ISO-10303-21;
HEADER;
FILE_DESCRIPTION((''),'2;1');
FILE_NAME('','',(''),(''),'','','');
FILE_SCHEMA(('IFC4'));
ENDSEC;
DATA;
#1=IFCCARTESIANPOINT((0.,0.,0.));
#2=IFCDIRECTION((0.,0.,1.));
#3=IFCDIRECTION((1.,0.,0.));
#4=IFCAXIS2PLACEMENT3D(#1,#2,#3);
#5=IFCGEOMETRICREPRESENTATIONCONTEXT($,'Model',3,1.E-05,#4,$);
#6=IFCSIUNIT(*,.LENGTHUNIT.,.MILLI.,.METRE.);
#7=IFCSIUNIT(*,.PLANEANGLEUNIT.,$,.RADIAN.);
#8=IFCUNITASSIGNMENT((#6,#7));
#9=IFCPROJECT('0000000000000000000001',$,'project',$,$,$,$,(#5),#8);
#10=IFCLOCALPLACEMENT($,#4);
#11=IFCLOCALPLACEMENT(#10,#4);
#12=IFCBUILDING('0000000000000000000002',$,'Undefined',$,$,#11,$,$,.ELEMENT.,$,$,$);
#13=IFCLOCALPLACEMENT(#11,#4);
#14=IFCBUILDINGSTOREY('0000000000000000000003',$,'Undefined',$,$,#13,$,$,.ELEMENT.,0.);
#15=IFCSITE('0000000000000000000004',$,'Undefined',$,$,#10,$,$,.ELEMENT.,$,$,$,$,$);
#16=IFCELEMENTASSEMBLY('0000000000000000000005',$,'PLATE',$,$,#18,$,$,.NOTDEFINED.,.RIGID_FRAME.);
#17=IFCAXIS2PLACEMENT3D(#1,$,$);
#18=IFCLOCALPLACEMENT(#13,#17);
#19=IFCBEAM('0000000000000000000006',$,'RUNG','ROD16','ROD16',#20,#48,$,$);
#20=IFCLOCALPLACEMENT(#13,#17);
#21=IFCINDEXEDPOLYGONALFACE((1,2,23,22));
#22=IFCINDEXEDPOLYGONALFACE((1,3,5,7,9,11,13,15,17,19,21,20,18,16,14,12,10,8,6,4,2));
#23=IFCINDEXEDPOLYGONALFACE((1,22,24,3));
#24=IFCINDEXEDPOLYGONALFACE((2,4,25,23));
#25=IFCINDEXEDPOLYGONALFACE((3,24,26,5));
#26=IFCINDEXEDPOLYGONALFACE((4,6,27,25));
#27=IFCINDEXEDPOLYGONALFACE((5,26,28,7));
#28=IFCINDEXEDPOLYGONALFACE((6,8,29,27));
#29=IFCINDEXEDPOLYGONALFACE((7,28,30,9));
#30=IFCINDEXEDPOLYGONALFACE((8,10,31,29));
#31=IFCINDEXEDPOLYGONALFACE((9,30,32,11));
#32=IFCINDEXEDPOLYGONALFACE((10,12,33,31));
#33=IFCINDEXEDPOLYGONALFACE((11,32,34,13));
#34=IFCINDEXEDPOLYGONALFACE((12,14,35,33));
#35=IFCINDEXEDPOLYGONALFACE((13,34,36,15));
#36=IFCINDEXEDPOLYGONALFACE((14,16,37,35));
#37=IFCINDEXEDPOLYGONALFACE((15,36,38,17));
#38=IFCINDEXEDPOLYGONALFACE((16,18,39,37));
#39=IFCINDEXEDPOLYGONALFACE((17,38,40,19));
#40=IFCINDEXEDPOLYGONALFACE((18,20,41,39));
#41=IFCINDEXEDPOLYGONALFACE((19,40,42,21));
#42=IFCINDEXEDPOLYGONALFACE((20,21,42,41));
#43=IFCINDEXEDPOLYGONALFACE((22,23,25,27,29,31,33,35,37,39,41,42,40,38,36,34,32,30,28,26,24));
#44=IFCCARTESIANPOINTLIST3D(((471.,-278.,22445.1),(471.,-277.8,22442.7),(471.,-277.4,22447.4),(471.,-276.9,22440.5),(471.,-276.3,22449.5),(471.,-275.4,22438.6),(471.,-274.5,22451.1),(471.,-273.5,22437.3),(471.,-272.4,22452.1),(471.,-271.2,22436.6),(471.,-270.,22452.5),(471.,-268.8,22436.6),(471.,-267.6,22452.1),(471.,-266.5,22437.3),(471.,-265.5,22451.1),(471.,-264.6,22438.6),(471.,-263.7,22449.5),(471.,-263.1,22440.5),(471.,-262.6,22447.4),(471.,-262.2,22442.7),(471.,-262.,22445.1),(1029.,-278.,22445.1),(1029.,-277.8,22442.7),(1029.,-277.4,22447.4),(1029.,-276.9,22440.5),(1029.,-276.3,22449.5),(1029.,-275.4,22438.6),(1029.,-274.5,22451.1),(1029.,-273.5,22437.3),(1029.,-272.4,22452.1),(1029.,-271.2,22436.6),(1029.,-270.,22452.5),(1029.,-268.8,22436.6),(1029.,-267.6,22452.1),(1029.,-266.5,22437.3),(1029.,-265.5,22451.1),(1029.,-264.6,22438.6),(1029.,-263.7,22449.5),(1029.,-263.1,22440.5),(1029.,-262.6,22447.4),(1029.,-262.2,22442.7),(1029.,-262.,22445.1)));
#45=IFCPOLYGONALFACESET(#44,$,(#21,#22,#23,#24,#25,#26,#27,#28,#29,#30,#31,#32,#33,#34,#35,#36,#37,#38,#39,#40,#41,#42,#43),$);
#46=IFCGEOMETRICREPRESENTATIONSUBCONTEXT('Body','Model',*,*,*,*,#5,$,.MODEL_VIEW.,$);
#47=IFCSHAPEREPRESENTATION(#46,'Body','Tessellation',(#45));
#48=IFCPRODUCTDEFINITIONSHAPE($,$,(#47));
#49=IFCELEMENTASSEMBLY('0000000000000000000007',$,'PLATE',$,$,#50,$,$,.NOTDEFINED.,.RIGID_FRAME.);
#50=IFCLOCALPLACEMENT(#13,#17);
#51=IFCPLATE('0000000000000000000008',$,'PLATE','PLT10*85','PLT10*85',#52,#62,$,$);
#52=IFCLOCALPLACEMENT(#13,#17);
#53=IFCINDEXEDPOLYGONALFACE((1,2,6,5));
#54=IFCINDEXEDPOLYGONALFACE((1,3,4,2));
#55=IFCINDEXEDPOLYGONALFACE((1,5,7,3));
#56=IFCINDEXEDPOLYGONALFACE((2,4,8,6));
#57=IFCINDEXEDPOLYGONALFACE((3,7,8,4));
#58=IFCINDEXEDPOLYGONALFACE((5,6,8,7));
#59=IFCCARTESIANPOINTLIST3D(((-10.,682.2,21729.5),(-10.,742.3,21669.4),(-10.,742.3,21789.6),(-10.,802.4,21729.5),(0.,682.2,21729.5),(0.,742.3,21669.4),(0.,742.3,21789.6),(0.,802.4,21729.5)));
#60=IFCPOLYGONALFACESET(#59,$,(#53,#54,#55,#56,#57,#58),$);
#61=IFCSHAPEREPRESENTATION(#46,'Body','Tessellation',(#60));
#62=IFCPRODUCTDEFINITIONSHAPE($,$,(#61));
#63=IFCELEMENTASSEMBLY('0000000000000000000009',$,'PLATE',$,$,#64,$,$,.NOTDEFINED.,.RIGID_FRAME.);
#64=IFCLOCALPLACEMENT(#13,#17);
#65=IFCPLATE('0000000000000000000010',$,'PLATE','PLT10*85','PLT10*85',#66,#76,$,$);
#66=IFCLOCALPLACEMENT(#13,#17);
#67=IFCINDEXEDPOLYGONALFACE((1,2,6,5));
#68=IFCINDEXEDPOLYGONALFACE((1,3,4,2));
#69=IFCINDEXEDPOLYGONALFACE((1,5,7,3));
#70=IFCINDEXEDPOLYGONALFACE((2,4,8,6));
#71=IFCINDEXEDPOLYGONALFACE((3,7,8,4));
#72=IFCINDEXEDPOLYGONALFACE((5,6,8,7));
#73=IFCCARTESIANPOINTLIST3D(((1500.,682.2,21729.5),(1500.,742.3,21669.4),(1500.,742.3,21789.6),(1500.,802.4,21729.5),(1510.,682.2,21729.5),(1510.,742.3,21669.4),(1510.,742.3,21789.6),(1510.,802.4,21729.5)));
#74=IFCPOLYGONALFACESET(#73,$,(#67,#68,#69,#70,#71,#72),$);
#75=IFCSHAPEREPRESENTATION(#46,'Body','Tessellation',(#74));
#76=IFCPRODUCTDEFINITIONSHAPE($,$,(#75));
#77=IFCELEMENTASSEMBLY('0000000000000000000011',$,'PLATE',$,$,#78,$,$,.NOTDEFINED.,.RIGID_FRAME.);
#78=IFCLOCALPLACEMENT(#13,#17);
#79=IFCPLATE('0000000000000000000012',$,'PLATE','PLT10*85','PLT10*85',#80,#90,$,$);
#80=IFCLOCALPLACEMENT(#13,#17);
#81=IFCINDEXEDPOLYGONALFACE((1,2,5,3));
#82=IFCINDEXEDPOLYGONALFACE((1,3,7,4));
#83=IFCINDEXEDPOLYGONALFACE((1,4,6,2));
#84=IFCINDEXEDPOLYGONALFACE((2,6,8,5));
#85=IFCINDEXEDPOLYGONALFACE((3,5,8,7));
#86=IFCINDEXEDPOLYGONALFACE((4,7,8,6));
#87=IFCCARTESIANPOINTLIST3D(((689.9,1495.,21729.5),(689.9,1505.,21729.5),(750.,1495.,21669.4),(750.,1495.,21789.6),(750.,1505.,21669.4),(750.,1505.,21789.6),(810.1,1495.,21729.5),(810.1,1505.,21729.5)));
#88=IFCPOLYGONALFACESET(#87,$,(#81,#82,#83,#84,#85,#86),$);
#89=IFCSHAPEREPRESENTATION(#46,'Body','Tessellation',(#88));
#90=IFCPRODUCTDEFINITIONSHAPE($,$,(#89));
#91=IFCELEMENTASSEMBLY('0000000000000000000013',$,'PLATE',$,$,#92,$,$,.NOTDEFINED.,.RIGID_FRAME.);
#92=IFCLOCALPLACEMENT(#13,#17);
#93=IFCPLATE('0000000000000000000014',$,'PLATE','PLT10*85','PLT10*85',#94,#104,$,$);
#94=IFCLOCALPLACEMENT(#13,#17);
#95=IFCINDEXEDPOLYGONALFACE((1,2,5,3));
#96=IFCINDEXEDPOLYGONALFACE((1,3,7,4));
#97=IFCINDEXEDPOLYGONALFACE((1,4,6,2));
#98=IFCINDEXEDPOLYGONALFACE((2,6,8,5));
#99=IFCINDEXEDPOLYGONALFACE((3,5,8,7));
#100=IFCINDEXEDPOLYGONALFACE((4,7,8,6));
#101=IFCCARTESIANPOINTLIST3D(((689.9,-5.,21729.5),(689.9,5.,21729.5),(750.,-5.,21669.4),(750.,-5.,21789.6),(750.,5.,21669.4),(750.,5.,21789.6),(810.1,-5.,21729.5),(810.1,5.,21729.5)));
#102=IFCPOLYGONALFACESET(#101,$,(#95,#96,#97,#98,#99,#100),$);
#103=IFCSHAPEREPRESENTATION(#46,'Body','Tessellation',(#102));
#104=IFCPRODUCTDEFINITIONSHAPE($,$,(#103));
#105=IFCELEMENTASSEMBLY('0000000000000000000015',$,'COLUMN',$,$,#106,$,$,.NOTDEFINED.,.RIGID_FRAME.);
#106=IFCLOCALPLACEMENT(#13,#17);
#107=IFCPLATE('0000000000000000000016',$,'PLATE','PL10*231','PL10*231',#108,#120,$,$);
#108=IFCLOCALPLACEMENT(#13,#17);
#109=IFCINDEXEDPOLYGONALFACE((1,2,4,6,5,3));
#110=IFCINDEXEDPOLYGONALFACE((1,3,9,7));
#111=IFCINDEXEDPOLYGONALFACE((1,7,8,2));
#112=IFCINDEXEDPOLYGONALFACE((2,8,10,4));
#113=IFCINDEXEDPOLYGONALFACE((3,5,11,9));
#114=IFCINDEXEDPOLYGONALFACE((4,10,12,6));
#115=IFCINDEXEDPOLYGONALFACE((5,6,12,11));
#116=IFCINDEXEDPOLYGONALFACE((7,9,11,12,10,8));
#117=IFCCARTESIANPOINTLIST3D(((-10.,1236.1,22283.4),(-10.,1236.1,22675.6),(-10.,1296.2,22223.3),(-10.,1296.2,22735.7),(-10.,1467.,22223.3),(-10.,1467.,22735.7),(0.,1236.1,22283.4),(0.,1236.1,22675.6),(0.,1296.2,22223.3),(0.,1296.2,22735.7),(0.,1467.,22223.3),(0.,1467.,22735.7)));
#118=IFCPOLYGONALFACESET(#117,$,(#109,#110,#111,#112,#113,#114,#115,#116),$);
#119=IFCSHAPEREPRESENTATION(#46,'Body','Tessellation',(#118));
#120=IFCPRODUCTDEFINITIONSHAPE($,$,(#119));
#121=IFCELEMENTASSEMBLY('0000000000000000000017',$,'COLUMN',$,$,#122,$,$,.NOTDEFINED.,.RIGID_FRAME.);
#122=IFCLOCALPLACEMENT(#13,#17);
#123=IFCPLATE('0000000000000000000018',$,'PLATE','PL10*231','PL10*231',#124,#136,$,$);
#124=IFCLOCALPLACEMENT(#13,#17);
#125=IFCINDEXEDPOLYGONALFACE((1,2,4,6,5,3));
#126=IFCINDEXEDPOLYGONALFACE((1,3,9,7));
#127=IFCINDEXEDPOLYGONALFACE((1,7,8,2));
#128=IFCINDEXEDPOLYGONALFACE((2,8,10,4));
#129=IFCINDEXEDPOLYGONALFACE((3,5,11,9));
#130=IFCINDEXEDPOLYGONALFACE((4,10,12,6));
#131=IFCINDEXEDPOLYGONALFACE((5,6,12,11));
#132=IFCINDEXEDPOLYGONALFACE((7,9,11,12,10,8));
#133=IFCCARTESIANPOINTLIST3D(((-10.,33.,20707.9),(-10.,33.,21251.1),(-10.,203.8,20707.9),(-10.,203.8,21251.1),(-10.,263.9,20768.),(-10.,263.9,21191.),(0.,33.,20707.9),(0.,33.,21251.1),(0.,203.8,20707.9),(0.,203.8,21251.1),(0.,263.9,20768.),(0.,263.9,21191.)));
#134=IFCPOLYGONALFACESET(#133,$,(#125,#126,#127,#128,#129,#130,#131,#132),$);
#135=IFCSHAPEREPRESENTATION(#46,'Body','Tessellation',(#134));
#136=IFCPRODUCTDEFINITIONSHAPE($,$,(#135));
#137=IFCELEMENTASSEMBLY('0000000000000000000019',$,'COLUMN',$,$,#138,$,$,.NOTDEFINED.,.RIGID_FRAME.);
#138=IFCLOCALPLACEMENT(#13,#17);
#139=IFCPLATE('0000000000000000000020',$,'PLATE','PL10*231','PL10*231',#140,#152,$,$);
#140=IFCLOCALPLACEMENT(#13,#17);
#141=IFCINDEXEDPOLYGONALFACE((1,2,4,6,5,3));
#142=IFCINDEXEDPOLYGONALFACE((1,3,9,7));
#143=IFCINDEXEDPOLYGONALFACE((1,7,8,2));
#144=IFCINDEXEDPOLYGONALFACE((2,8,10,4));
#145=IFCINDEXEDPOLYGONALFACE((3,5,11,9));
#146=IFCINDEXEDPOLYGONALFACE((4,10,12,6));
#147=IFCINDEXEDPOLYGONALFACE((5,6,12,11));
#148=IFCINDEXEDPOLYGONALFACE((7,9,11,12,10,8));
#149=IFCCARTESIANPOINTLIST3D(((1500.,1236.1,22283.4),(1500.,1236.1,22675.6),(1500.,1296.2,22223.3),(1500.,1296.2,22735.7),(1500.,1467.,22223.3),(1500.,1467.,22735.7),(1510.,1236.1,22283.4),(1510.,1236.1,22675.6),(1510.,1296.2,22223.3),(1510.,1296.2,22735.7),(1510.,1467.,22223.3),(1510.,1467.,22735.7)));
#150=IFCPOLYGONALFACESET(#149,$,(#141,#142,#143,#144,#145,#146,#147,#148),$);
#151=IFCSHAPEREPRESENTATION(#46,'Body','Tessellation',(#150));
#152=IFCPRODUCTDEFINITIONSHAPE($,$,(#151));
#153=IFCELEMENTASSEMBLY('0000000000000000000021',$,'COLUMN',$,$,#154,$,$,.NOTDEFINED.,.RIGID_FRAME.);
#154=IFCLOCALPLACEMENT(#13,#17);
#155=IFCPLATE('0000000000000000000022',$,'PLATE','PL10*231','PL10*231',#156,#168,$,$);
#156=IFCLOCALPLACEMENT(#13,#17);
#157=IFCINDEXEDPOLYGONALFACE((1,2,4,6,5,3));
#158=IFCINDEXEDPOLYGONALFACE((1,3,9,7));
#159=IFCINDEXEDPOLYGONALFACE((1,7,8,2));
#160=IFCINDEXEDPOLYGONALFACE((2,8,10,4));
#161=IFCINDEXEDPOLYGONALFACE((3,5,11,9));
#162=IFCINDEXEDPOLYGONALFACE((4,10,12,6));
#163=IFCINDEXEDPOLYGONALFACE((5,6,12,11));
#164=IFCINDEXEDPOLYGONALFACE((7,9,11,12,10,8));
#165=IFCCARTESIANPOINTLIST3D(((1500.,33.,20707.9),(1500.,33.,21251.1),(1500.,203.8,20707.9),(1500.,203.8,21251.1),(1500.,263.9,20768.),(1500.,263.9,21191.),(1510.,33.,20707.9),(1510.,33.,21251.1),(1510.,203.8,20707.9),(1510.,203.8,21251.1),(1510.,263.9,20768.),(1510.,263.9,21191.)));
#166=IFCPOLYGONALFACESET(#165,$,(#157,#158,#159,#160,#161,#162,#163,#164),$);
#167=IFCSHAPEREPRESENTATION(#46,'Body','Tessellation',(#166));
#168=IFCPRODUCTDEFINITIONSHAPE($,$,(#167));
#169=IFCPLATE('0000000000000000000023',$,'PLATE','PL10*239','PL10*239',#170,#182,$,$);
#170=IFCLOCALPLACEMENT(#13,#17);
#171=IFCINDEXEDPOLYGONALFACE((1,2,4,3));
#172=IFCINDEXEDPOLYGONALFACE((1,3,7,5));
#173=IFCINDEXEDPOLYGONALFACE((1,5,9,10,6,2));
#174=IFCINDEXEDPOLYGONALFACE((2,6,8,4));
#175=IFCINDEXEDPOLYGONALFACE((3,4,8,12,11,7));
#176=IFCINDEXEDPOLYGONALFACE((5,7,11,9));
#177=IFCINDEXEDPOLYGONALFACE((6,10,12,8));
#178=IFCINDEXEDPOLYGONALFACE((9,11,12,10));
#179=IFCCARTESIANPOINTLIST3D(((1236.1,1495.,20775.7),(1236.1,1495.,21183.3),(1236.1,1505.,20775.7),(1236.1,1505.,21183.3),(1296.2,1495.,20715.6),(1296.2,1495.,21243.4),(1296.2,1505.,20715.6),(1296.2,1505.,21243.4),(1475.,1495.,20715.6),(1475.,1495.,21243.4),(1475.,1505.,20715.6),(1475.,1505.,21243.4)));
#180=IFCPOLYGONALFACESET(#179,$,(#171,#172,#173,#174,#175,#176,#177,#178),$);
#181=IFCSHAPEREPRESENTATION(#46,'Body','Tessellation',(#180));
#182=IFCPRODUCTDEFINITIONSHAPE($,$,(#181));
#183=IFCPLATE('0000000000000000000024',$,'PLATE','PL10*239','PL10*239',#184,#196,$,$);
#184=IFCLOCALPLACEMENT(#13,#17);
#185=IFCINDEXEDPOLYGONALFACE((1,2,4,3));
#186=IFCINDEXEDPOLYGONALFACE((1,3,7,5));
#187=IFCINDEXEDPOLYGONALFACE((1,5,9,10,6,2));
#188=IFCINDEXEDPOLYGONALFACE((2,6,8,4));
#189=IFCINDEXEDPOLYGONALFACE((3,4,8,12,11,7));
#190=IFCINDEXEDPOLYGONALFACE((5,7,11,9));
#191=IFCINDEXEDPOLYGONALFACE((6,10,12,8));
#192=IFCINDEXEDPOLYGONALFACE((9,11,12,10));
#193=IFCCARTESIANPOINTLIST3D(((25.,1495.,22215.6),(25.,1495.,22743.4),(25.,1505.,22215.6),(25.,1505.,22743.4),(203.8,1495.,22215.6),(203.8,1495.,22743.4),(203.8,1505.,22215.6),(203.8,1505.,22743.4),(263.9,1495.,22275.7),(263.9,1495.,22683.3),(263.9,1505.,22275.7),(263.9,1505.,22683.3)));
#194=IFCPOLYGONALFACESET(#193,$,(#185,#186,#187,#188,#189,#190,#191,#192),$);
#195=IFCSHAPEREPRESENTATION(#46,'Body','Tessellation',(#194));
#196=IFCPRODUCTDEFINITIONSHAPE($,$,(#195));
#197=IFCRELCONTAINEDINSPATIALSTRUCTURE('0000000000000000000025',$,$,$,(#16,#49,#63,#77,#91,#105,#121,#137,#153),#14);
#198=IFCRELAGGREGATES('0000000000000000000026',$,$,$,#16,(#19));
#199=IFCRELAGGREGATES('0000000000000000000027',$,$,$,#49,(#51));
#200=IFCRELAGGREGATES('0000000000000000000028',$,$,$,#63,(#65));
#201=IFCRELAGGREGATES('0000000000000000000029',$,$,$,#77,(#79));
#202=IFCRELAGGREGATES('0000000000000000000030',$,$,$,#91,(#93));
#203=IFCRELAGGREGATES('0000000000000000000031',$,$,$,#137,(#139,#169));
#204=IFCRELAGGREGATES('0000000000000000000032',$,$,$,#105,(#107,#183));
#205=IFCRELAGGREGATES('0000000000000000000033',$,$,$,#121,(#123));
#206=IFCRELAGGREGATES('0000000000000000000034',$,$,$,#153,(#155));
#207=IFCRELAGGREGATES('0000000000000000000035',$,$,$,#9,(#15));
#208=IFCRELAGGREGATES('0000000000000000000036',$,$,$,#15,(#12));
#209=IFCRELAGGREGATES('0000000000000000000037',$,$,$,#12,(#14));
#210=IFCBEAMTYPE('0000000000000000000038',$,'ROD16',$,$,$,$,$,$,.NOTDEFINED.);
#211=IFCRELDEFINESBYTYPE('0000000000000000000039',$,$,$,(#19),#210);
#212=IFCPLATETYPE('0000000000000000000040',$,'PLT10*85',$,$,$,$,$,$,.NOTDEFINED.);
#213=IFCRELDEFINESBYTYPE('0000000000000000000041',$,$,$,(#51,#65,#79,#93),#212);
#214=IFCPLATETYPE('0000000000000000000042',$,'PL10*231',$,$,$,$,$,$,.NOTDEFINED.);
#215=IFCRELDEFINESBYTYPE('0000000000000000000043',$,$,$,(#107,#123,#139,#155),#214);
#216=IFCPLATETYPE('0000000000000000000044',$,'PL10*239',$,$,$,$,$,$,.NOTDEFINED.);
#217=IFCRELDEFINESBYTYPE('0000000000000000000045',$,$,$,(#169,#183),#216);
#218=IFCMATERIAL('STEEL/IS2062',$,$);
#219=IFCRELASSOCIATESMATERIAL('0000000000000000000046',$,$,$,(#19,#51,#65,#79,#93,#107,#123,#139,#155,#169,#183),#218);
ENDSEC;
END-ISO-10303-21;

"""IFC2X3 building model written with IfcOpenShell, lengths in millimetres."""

from ifc_helpers import new_model, si_unit, frame, origin_with_axes, origin_2d_with_axis, place, context, subcontext, project, spatial, polyline, circle, outline, extrude, material, type_object, element, aggregate, save


model = new_model("IFC2X3")

# Units and contexts
model_context = context("Model", 3, precision=1e-05, world=origin_with_axes())
body_context = subcontext(model_context, "Body", "Model", "MODEL_VIEW")
ifc_project = project(units=[si_unit("LENGTHUNIT", "METRE", prefix="MILLI"), si_unit("PLANEANGLEUNIT", "RADIAN")], contexts=[model_context])

# Site, building, storey
site_placement = place(None, origin_with_axes())
site = spatial("IfcSite", under=ifc_project, at=site_placement, Name="Undefined", CompositionType="ELEMENT")
building_placement = place(site_placement, origin_with_axes())
building = spatial("IfcBuilding", under=site, at=building_placement, Name="Undefined", CompositionType="ELEMENT")
storey_placement = place(building_placement, origin_with_axes())
storey = spatial("IfcBuildingStorey", under=building, at=storey_placement, Name="Undefined", CompositionType="ELEMENT", Elevation=0.0)

# Shared definitions
ifc_material = material(Name="STEEL/IS2062")

# Element assembly, beam
assembly_1_placement = place(storey_placement, origin_with_axes())
assembly_1 = element("IfcElementAssembly", 1, at=assembly_1_placement, inside=storey, Name="PLATE", AssemblyPlace="NOTDEFINED", PredefinedType="RIGID_FRAME")
beam_type_1 = type_object("IfcBeamType", Name="ROD16", PredefinedType="NOTDEFINED")
beam_1_placement = place(assembly_1_placement, frame((471.0, -270.0, 22444.5), z_axis=(0.0, 1.0, 0.0), x_axis=(1.0, 0.0, 0.0)))
beam_1 = element("IfcBeam", 2, at=beam_1_placement, type_object=beam_type_1, material=ifc_material, Name="RUNG", Description="ROD16", ObjectType="ROD16", context=body_context, shape_type="SweptSolid", body=[
    extrude(circle(Radius=8.0, at=origin_2d_with_axis()), frame((558.0, 0.0, 0.0), z_axis=(-1.0, 0.0, 0.0), x_axis=(0.0, -1.0, 0.0)), (0.0, 0.0, 1.0), 558.0),
])
aggregate(assembly_1, [beam_1])

# Element assemblies, plates
assembly_2_placement = place(storey_placement, origin_with_axes())
assembly_2 = element("IfcElementAssembly", 3, at=assembly_2_placement, inside=storey, Name="PLATE", AssemblyPlace="NOTDEFINED", PredefinedType="RIGID_FRAME")
plate_type_1 = type_object("IfcPlateType", Name="PLT10*85", PredefinedType="NOTDEFINED")
plate_1_placement = place(assembly_2_placement, frame((-5.0, 742.3, 21789.6), z_axis=(1.0, 0.0, 0.0), x_axis=(0.0, -0.707107, -0.707107)))
plate_1 = element("IfcPlate", 4, at=plate_1_placement, type_object=plate_type_1, material=ifc_material, Name="PLATE", Description="PLT10*85", ObjectType="PLT10*85", context=body_context, shape_type="SweptSolid", body=[
    extrude(outline(polyline([(0.0, 0.0), (85.0, 0.0), (85.0, 85.0), (0.0, 85.0), (0.0, 0.0)])), frame((0.0, 0.0, -5.0), z_axis=(0.0, 0.0, 1.0), x_axis=(1.0, 0.0, 0.0)), (0.0, 0.0, 1.0), 10.0),
])
aggregate(assembly_2, [plate_1])
assembly_3_placement = place(storey_placement, origin_with_axes())
assembly_3 = element("IfcElementAssembly", 5, at=assembly_3_placement, inside=storey, Name="PLATE", AssemblyPlace="NOTDEFINED", PredefinedType="RIGID_FRAME")
plate_2_placement = place(assembly_3_placement, frame((1505.0, 742.3, 21789.6), z_axis=(1.0, 0.0, 0.0), x_axis=(0.0, -0.707107, -0.707107)))
plate_2 = element("IfcPlate", 6, at=plate_2_placement, type_object=plate_type_1, material=ifc_material, Name="PLATE", Description="PLT10*85", ObjectType="PLT10*85", context=body_context, shape_type="SweptSolid", body=[
    extrude(outline(polyline([(0.0, 0.0), (85.0, 0.0), (85.0, 85.0), (0.0, 85.0), (0.0, 0.0)])), frame((0.0, 0.0, -5.0), z_axis=(0.0, 0.0, 1.0), x_axis=(1.0, 0.0, 0.0)), (0.0, 0.0, 1.0), 10.0),
])
aggregate(assembly_3, [plate_2])
assembly_4_placement = place(storey_placement, origin_with_axes())
assembly_4 = element("IfcElementAssembly", 7, at=assembly_4_placement, inside=storey, Name="PLATE", AssemblyPlace="NOTDEFINED", PredefinedType="RIGID_FRAME")
plate_3_placement = place(assembly_4_placement, frame((750.0, 1500.0, 21789.6), z_axis=(0.0, -1.0, 0.0), x_axis=(-0.707107, 0.0, -0.707107)))
plate_3 = element("IfcPlate", 8, at=plate_3_placement, type_object=plate_type_1, material=ifc_material, Name="PLATE", Description="PLT10*85", ObjectType="PLT10*85", context=body_context, shape_type="SweptSolid", body=[
    extrude(outline(polyline([(0.0, 0.0), (85.0, 0.0), (85.0, 85.0), (0.0, 85.0), (0.0, 0.0)])), frame((0.0, 0.0, -5.0), z_axis=(0.0, 0.0, 1.0), x_axis=(1.0, 0.0, 0.0)), (0.0, 0.0, 1.0), 10.0),
])
aggregate(assembly_4, [plate_3])
assembly_5_placement = place(storey_placement, origin_with_axes())
assembly_5 = element("IfcElementAssembly", 9, at=assembly_5_placement, inside=storey, Name="PLATE", AssemblyPlace="NOTDEFINED", PredefinedType="RIGID_FRAME")
plate_4_placement = place(assembly_5_placement, frame((750.0, 0.0, 21789.6), z_axis=(0.0, -1.0, 0.0), x_axis=(-0.707107, 0.0, -0.707107)))
plate_4 = element("IfcPlate", 10, at=plate_4_placement, type_object=plate_type_1, material=ifc_material, Name="PLATE", Description="PLT10*85", ObjectType="PLT10*85", context=body_context, shape_type="SweptSolid", body=[
    extrude(outline(polyline([(0.0, 0.0), (85.0, 0.0), (85.0, 85.0), (0.0, 85.0), (0.0, 0.0)])), frame((0.0, 0.0, -5.0), z_axis=(0.0, 0.0, 1.0), x_axis=(1.0, 0.0, 0.0)), (0.0, 0.0, 1.0), 10.0),
])
aggregate(assembly_5, [plate_4])
assembly_6_placement = place(storey_placement, origin_with_axes())
assembly_6 = element("IfcElementAssembly", 11, at=assembly_6_placement, inside=storey, Name="COLUMN", AssemblyPlace="NOTDEFINED", PredefinedType="RIGID_FRAME")
plate_type_2 = type_object("IfcPlateType", Name="PL10*231", PredefinedType="NOTDEFINED")
plate_5_placement = place(assembly_6_placement, frame((-5.0, 1467.0, 22223.3), z_axis=(1.0, 0.0, 0.0), x_axis=(0.0, 0.0, 1.0)))
plate_5 = element("IfcPlate", 12, at=plate_5_placement, type_object=plate_type_2, material=ifc_material, Name="PLATE", Description="PL10*231", ObjectType="PL10*231", context=body_context, shape_type="SweptSolid", body=[
    extrude(outline(polyline([(0.0, 0.0), (512.3, 0.0), (512.3, 170.8), (452.2, 230.9), (60.1, 230.9), (0.0, 170.8), (0.0, 0.0)])), frame((0.0, 0.0, -5.0), z_axis=(0.0, 0.0, 1.0), x_axis=(1.0, 0.0, 0.0)), (0.0, 0.0, 1.0), 10.0),
])
assembly_7_placement = place(storey_placement, origin_with_axes())
assembly_7 = element("IfcElementAssembly", 13, at=assembly_7_placement, inside=storey, Name="COLUMN", AssemblyPlace="NOTDEFINED", PredefinedType="RIGID_FRAME")
plate_6_placement = place(assembly_7_placement, frame((-5.0, 33.0, 21251.1), z_axis=(1.0, 0.0, 0.0), x_axis=(0.0, 0.0, -1.0)))
plate_6 = element("IfcPlate", 14, at=plate_6_placement, type_object=plate_type_2, material=ifc_material, Name="PLATE", Description="PL10*231", ObjectType="PL10*231", context=body_context, shape_type="SweptSolid", body=[
    extrude(outline(polyline([(0.0, 0.0), (543.3, 0.0), (543.3, 170.8), (483.2, 230.9), (60.1, 230.9), (0.0, 170.8), (0.0, 0.0)])), frame((0.0, 0.0, -5.0), z_axis=(0.0, 0.0, 1.0), x_axis=(1.0, 0.0, 0.0)), (0.0, 0.0, 1.0), 10.0),
])
assembly_8_placement = place(storey_placement, origin_with_axes())
assembly_8 = element("IfcElementAssembly", 15, at=assembly_8_placement, inside=storey, Name="COLUMN", AssemblyPlace="NOTDEFINED", PredefinedType="RIGID_FRAME")
plate_7_placement = place(assembly_8_placement, frame((1505.0, 1467.0, 22223.3), z_axis=(1.0, 0.0, 0.0), x_axis=(0.0, 0.0, 1.0)))
plate_7 = element("IfcPlate", 16, at=plate_7_placement, type_object=plate_type_2, material=ifc_material, Name="PLATE", Description="PL10*231", ObjectType="PL10*231", context=body_context, shape_type="SweptSolid", body=[
    extrude(outline(polyline([(0.0, 0.0), (512.3, 0.0), (512.3, 170.8), (452.2, 230.9), (60.1, 230.9), (0.0, 170.8), (0.0, 0.0)])), frame((0.0, 0.0, -5.0), z_axis=(0.0, 0.0, 1.0), x_axis=(1.0, 0.0, 0.0)), (0.0, 0.0, 1.0), 10.0),
])
assembly_9_placement = place(storey_placement, origin_with_axes())
assembly_9 = element("IfcElementAssembly", 17, at=assembly_9_placement, inside=storey, Name="COLUMN", AssemblyPlace="NOTDEFINED", PredefinedType="RIGID_FRAME")
plate_8_placement = place(assembly_9_placement, frame((1505.0, 33.0, 21251.1), z_axis=(1.0, 0.0, 0.0), x_axis=(0.0, 0.0, -1.0)))
plate_8 = element("IfcPlate", 18, at=plate_8_placement, type_object=plate_type_2, material=ifc_material, Name="PLATE", Description="PL10*231", ObjectType="PL10*231", context=body_context, shape_type="SweptSolid", body=[
    extrude(outline(polyline([(0.0, 0.0), (543.3, 0.0), (543.3, 170.8), (483.2, 230.9), (60.1, 230.9), (0.0, 170.8), (0.0, 0.0)])), frame((0.0, 0.0, -5.0), z_axis=(0.0, 0.0, 1.0), x_axis=(1.0, 0.0, 0.0)), (0.0, 0.0, 1.0), 10.0),
])

# Plates
plate_type_3 = type_object("IfcPlateType", Name="PL10*239", PredefinedType="NOTDEFINED")
plate_9_placement = place(assembly_8_placement, frame((1475.0, 1500.0, 21243.4), z_axis=(0.0, 1.0, 0.0), x_axis=(0.0, 0.0, -1.0)))
plate_9 = element("IfcPlate", 19, at=plate_9_placement, type_object=plate_type_3, material=ifc_material, Name="PLATE", Description="PL10*239", ObjectType="PL10*239", context=body_context, shape_type="SweptSolid", body=[
    extrude(outline(polyline([(0.0, 0.0), (527.8, 0.0), (527.8, 178.8), (467.7, 238.9), (60.1, 238.9), (0.0, 178.8), (0.0, 0.0)])), frame((0.0, 0.0, -5.0), z_axis=(0.0, 0.0, 1.0), x_axis=(1.0, 0.0, 0.0)), (0.0, 0.0, 1.0), 10.0),
])
aggregate(assembly_8, [plate_7, plate_9])
plate_10_placement = place(assembly_6_placement, frame((25.0, 1500.0, 22215.6), z_axis=(0.0, 1.0, 0.0), x_axis=(0.0, 0.0, 1.0)))
plate_10 = element("IfcPlate", 20, at=plate_10_placement, type_object=plate_type_3, material=ifc_material, Name="PLATE", Description="PL10*239", ObjectType="PL10*239", context=body_context, shape_type="SweptSolid", body=[
    extrude(outline(polyline([(0.0, 0.0), (527.8, 0.0), (527.8, 178.8), (467.7, 238.9), (60.1, 238.9), (0.0, 178.8), (0.0, 0.0)])), frame((0.0, 0.0, -5.0), z_axis=(0.0, 0.0, 1.0), x_axis=(1.0, 0.0, 0.0)), (0.0, 0.0, 1.0), 10.0),
])
aggregate(assembly_6, [plate_5, plate_10])
aggregate(assembly_7, [plate_6])
aggregate(assembly_9, [plate_8])

save(model, "model.ifc")
